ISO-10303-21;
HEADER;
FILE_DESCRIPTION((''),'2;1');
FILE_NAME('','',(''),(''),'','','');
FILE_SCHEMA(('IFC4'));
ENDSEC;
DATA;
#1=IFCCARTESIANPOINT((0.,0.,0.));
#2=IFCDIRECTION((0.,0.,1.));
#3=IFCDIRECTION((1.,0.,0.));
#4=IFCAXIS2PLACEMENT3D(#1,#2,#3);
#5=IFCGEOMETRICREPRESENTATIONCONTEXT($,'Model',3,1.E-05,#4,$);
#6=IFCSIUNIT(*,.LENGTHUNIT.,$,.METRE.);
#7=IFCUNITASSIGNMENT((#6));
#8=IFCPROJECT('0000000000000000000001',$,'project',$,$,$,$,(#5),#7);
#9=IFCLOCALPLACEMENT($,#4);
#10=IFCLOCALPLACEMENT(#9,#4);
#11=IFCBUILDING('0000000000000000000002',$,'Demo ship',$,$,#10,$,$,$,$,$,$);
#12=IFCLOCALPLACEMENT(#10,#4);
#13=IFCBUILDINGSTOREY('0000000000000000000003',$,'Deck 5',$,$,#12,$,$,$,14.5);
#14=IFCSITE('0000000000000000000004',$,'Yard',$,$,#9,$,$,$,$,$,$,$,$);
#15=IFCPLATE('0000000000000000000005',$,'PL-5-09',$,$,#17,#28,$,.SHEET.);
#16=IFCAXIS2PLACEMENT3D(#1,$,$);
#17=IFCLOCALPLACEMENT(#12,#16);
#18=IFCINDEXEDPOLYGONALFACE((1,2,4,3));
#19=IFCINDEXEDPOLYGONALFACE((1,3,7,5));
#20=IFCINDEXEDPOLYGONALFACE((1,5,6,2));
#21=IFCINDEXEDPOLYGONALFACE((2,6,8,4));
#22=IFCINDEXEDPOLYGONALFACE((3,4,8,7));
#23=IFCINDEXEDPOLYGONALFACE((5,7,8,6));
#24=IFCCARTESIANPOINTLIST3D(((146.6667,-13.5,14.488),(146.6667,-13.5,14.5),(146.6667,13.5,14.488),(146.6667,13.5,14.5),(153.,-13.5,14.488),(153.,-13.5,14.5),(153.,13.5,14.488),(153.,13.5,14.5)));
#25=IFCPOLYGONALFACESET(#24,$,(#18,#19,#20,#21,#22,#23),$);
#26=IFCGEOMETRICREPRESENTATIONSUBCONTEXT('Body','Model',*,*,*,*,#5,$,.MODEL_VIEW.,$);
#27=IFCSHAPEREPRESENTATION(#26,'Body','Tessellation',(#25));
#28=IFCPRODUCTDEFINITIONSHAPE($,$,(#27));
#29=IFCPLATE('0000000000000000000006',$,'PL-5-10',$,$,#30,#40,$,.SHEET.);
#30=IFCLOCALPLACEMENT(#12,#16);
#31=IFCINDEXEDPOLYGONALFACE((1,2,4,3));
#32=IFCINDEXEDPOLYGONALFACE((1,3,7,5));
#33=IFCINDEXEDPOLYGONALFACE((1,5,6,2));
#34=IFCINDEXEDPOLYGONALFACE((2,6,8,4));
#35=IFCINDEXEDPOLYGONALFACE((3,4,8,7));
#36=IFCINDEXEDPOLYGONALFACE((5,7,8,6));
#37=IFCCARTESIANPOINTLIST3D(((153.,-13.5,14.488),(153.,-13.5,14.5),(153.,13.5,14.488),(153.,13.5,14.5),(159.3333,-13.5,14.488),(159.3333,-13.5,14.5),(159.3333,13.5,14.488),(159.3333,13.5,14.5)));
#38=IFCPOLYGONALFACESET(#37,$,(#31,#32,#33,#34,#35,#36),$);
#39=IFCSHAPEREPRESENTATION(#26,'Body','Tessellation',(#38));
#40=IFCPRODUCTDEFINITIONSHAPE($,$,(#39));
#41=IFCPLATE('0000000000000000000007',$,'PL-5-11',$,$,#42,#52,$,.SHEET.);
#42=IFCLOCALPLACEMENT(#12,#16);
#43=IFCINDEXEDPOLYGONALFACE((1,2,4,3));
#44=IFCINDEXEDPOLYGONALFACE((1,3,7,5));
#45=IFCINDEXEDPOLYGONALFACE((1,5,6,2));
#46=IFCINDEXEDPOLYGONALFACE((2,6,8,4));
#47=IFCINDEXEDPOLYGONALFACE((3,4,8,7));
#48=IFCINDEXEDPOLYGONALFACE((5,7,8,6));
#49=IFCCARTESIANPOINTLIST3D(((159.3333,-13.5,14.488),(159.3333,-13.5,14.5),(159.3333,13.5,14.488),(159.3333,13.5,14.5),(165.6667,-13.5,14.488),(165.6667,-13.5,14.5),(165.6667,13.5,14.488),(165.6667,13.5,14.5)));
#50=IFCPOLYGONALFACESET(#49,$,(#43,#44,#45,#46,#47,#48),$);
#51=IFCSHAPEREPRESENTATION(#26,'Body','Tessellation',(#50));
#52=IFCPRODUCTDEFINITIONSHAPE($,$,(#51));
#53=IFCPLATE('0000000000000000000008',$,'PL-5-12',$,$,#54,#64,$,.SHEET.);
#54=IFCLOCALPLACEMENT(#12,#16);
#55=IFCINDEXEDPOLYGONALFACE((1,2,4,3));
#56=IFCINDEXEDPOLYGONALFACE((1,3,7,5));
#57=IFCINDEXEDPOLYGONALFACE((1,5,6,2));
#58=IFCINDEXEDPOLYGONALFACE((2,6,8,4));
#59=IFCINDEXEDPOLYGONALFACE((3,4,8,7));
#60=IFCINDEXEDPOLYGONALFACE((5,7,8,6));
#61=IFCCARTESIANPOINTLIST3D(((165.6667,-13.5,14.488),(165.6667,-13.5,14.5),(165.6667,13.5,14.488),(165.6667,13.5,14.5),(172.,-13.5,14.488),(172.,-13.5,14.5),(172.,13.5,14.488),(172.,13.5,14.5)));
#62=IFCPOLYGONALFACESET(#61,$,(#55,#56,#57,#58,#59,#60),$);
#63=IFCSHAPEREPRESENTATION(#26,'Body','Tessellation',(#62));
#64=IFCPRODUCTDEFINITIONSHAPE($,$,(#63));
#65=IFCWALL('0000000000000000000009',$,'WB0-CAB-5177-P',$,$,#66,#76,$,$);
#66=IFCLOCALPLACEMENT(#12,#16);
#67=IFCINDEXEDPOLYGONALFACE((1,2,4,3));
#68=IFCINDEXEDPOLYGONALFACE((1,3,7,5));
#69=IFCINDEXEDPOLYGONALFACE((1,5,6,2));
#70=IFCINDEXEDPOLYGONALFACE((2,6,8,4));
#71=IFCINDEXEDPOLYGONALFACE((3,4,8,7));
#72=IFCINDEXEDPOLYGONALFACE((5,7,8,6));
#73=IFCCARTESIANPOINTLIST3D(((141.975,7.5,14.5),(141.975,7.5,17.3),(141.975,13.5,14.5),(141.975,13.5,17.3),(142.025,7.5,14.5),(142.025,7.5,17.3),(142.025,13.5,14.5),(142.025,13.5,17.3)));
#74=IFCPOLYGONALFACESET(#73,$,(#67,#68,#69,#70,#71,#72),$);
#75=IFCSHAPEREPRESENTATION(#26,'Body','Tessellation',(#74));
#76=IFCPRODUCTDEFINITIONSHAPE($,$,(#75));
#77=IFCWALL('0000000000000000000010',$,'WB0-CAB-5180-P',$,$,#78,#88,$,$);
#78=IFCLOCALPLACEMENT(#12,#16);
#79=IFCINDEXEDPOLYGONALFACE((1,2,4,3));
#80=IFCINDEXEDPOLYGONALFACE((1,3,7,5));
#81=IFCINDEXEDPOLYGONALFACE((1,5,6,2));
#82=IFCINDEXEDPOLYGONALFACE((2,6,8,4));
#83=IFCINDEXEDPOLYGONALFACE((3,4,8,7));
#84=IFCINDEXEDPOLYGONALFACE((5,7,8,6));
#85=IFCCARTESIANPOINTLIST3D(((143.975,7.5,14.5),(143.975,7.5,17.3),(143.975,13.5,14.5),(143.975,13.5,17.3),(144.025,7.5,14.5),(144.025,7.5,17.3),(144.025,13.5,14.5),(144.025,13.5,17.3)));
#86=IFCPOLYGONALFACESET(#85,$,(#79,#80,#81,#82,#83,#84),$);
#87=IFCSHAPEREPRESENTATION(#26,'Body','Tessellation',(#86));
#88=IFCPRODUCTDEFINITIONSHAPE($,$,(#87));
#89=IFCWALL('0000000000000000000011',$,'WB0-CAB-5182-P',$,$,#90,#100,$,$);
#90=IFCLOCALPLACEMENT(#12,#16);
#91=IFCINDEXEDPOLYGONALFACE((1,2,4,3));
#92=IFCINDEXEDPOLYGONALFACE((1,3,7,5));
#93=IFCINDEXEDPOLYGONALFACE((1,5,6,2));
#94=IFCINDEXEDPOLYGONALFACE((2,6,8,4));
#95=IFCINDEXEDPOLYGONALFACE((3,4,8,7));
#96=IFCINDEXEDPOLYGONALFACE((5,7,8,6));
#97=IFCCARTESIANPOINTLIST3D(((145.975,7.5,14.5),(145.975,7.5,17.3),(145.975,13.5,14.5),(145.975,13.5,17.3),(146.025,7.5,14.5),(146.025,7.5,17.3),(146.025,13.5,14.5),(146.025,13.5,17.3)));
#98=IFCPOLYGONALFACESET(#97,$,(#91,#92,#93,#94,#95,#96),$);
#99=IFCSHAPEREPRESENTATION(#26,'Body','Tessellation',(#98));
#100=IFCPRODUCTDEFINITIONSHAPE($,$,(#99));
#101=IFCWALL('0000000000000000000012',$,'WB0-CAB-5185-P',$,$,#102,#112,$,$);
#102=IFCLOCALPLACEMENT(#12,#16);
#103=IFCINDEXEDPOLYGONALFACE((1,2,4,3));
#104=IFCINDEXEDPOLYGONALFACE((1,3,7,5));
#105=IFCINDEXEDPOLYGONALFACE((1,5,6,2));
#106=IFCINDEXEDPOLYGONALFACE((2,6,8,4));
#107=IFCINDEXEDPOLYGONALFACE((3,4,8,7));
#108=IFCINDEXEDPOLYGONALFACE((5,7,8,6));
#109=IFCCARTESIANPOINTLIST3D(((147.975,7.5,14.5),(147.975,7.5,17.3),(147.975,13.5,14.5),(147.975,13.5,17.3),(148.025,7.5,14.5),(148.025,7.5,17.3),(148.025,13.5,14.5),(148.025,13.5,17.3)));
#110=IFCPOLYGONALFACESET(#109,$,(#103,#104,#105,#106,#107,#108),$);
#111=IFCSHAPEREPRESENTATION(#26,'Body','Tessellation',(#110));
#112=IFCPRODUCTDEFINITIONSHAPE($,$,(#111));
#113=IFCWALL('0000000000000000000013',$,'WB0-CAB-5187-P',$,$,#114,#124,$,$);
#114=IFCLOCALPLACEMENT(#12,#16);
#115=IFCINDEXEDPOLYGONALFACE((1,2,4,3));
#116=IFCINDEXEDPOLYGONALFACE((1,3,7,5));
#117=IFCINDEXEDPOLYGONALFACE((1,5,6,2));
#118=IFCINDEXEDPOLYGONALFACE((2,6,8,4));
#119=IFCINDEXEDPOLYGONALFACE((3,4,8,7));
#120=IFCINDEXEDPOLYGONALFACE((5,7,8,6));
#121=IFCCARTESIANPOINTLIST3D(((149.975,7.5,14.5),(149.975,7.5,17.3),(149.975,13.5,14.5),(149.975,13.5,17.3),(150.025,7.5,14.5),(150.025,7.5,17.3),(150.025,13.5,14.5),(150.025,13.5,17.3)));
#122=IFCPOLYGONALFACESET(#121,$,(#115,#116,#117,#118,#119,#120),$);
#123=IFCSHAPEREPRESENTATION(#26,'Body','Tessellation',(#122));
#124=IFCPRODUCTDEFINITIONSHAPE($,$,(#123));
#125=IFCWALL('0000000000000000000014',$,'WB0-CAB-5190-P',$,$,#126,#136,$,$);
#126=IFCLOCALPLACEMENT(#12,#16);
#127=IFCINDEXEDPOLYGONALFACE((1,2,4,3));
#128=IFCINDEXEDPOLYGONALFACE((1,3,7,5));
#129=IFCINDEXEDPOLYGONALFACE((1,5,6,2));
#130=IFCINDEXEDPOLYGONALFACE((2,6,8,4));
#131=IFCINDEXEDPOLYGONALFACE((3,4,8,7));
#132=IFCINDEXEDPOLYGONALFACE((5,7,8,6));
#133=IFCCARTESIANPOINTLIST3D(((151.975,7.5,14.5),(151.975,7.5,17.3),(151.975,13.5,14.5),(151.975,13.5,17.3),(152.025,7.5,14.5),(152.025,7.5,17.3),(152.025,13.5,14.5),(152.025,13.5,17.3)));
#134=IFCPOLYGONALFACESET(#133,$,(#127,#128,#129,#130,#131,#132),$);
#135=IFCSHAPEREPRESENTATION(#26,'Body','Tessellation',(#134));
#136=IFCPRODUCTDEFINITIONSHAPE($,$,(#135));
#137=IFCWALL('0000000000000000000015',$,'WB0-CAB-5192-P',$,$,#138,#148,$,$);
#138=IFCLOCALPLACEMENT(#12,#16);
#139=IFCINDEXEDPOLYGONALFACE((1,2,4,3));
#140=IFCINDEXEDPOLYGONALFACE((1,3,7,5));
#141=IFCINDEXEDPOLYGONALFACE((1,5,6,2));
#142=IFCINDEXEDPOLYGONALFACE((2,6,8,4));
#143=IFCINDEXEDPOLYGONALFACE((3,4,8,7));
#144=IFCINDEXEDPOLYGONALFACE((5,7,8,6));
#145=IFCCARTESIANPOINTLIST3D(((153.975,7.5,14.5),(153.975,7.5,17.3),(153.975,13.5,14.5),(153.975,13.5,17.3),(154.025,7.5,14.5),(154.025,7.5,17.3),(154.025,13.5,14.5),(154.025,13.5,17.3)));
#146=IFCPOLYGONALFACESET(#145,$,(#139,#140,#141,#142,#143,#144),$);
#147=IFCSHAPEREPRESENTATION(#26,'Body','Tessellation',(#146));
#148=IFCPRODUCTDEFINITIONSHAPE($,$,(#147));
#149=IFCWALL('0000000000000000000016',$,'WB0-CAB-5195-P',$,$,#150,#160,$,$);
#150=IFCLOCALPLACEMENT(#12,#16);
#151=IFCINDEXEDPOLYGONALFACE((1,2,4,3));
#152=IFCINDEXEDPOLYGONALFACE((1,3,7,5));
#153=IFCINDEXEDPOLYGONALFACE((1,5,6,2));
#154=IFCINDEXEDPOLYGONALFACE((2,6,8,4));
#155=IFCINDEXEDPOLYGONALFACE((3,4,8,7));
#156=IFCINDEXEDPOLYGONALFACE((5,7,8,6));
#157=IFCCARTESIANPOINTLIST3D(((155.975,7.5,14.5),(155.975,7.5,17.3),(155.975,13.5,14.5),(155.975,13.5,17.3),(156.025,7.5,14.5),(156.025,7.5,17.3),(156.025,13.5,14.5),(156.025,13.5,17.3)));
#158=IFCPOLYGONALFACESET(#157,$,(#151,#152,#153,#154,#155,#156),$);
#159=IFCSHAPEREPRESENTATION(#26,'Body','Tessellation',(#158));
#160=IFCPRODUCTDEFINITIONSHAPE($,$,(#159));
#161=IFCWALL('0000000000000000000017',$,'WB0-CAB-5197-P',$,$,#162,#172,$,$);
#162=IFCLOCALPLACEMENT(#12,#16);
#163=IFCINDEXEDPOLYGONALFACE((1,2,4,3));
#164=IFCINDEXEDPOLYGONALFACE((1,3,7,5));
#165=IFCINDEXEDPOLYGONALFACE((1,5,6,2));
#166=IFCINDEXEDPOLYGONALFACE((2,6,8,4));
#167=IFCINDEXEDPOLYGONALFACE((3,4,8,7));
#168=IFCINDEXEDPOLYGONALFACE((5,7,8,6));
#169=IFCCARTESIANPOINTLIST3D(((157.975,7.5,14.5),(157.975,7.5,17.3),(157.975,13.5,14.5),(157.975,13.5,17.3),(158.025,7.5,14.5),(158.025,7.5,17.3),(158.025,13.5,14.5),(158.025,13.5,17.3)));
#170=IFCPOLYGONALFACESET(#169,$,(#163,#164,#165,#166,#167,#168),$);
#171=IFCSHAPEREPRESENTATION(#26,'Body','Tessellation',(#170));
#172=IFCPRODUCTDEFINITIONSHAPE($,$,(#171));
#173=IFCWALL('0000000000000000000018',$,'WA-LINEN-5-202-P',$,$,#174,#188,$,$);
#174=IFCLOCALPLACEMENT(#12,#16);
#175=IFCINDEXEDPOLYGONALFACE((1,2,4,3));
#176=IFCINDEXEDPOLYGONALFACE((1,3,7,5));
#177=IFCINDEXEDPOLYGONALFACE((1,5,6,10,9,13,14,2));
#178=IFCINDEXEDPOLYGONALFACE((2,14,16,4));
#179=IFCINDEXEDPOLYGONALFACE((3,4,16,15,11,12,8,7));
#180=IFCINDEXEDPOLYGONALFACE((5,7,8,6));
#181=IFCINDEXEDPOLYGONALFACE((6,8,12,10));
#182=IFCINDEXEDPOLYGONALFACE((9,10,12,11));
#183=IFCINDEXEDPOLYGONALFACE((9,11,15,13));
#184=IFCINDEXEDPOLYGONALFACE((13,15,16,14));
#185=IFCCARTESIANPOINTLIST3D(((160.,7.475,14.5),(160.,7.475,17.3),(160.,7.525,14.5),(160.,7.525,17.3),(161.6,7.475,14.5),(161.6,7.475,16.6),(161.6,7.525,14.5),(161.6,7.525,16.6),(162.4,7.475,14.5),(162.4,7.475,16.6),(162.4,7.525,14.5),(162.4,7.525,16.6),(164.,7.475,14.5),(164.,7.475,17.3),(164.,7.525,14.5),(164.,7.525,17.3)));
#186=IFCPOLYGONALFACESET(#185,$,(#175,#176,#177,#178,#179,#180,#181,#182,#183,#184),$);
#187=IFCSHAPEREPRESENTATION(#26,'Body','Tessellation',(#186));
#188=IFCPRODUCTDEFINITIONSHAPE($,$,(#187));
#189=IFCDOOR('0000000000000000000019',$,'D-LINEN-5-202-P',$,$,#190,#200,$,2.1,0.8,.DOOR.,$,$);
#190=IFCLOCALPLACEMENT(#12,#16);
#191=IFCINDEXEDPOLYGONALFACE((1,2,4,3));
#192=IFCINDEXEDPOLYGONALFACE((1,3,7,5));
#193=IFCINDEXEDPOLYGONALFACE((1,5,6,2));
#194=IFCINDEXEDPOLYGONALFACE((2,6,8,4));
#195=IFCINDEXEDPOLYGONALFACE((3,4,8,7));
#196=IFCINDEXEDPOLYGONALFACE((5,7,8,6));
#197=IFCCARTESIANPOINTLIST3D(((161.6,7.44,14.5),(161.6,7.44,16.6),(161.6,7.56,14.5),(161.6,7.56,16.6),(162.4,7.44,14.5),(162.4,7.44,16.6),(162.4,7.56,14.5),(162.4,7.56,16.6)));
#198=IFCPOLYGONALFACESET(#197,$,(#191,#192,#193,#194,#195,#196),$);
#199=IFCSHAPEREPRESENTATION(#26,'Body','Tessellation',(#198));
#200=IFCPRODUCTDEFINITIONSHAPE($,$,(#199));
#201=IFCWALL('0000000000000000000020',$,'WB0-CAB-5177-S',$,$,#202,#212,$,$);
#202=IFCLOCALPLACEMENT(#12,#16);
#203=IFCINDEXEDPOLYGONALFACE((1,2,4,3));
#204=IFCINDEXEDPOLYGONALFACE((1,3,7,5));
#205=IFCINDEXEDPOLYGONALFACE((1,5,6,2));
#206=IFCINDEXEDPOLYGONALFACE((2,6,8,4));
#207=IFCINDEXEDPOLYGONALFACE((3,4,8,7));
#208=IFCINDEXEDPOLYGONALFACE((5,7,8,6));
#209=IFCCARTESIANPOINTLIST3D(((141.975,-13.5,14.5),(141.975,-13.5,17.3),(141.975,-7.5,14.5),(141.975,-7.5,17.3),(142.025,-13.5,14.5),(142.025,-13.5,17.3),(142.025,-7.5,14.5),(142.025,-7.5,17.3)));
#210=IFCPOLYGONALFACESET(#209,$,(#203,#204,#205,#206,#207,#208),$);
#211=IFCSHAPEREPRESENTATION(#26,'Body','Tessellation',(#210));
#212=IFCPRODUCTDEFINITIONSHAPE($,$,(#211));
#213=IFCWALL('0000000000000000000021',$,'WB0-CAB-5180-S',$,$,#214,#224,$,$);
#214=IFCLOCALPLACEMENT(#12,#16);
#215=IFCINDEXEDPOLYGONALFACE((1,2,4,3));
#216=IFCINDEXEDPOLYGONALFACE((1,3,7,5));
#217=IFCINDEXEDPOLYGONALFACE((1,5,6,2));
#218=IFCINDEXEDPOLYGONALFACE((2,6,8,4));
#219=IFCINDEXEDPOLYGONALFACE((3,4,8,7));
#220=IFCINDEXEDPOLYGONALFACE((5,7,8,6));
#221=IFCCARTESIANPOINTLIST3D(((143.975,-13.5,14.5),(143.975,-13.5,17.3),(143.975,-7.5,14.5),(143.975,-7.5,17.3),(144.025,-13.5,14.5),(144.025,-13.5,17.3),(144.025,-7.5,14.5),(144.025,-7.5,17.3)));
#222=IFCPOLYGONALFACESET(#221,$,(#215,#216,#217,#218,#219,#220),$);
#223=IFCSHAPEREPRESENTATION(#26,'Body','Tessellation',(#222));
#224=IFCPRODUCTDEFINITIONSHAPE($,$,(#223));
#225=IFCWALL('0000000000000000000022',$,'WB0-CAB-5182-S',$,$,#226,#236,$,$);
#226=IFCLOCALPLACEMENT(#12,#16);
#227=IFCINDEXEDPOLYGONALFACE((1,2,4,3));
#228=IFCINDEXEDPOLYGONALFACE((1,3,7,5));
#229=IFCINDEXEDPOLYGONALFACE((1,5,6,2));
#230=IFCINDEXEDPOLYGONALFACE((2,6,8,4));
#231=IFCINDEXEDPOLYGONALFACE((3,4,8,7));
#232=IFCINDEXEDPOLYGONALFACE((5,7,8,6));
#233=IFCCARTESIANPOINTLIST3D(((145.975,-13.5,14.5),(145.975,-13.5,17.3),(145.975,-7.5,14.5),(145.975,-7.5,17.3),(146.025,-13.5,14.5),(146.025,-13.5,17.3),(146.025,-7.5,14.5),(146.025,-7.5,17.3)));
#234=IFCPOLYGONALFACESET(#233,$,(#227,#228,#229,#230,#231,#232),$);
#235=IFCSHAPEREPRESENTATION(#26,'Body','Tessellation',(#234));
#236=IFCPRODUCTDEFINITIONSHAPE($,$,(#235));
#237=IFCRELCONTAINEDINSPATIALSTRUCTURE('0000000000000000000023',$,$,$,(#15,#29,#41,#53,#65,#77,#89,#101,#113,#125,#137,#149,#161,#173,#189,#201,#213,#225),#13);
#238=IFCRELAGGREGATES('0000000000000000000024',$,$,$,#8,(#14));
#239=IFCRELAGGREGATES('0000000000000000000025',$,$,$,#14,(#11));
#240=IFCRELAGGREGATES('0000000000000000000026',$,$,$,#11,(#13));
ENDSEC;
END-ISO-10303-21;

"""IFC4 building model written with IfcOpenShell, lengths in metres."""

from ifc_helpers import new_model, si_unit, frame, frame_2d, origin, origin_with_axes, place, context, subcontext, project, spatial, rectangle, extrude, element, fill, save


model = new_model("IFC4")

# Units and contexts
model_context = context("Model", 3, precision=1e-05, world=origin_with_axes())
body_context = subcontext(model_context, "Body", "Model", "MODEL_VIEW")
ifc_project = project(units=[si_unit("LENGTHUNIT", "METRE")], contexts=[model_context])

# Site, building, storey
site_placement = place(None, origin_with_axes())
site = spatial("IfcSite", under=ifc_project, at=site_placement, Name="Yard")
building_placement = place(site_placement, origin_with_axes())
building = spatial("IfcBuilding", under=site, at=building_placement, Name="Demo ship")
storey_placement = place(building_placement, origin_with_axes())
storey = spatial("IfcBuildingStorey", under=building, at=storey_placement, Name="Deck 5", Elevation=14.5)

# Plates
for number, where, z_axis, x_axis, name in (
    (1, (146.6667, -13.5, 14.488), (0.0, 0.0, 1.0), (1.0, 0.0, 0.0), "PL-5-09"),
    (2, (153.0, -13.5, 14.488), (0.0, 0.0, 1.0), (1.0, 0.0, 0.0), "PL-5-10"),
):
    element("IfcPlate", number, at=place(storey_placement, frame(where, z_axis=z_axis, x_axis=x_axis)), inside=storey, Name=name, PredefinedType="SHEET", context=body_context, shape_type="SweptSolid", body=[
        extrude(rectangle(XDim=6.3333, YDim=27.0, at=frame_2d((3.1667, 13.5))), origin(), (0.0, 0.0, 1.0), 0.012),
    ])
plate_1_placement = place(storey_placement, frame((159.3333, -13.5, 14.488), z_axis=(0.0, 0.0, 1.0), x_axis=(1.0, 0.0, 0.0)))
element("IfcPlate", 3, at=plate_1_placement, inside=storey, Name="PL-5-11", PredefinedType="SHEET", context=body_context, shape_type="SweptSolid", body=[
    extrude(rectangle(XDim=6.3334, YDim=27.0, at=frame_2d((3.1667, 13.5))), origin(), (0.0, 0.0, 1.0), 0.012),
])
plate_2_placement = place(storey_placement, frame((165.6667, -13.5, 14.488), z_axis=(0.0, 0.0, 1.0), x_axis=(1.0, 0.0, 0.0)))
element("IfcPlate", 4, at=plate_2_placement, inside=storey, Name="PL-5-12", PredefinedType="SHEET", context=body_context, shape_type="SweptSolid", body=[
    extrude(rectangle(XDim=6.3333, YDim=27.0, at=frame_2d((3.1667, 13.5))), origin(), (0.0, 0.0, 1.0), 0.012),
])

# Walls
for number, where, z_axis, x_axis, name in (
    (5, (141.975, 7.5, 14.5), (0.0, 0.0, 1.0), (1.0, 0.0, 0.0), "WB0-CAB-5177-P"),
    (6, (143.975, 7.5, 14.5), (0.0, 0.0, 1.0), (1.0, 0.0, 0.0), "WB0-CAB-5180-P"),
    (7, (145.975, 7.5, 14.5), (0.0, 0.0, 1.0), (1.0, 0.0, 0.0), "WB0-CAB-5182-P"),
    (8, (147.975, 7.5, 14.5), (0.0, 0.0, 1.0), (1.0, 0.0, 0.0), "WB0-CAB-5185-P"),
    (9, (149.975, 7.5, 14.5), (0.0, 0.0, 1.0), (1.0, 0.0, 0.0), "WB0-CAB-5187-P"),
    (10, (151.975, 7.5, 14.5), (0.0, 0.0, 1.0), (1.0, 0.0, 0.0), "WB0-CAB-5190-P"),
    (11, (153.975, 7.5, 14.5), (0.0, 0.0, 1.0), (1.0, 0.0, 0.0), "WB0-CAB-5192-P"),
    (12, (155.975, 7.5, 14.5), (0.0, 0.0, 1.0), (1.0, 0.0, 0.0), "WB0-CAB-5195-P"),
    (13, (157.975, 7.5, 14.5), (0.0, 0.0, 1.0), (1.0, 0.0, 0.0), "WB0-CAB-5197-P"),
):
    element("IfcWall", number, at=place(storey_placement, frame(where, z_axis=z_axis, x_axis=x_axis)), inside=storey, Name=name, context=body_context, shape_type="SweptSolid", body=[
        extrude(rectangle(XDim=0.05, YDim=6.0, at=frame_2d((0.025, 3.0))), origin(), (0.0, 0.0, 1.0), 2.8),
    ])

# Wall, opening, door
wall_1_placement = place(storey_placement, frame((160.0, 7.475, 14.5), z_axis=(0.0, 0.0, 1.0), x_axis=(1.0, 0.0, 0.0)))
wall_1 = element("IfcWall", 14, at=wall_1_placement, inside=storey, Name="WA-LINEN-5-202-P", context=body_context, shape_type="SweptSolid", body=[
    extrude(rectangle(XDim=4.0, YDim=0.05, at=frame_2d((2.0, 0.025))), origin(), (0.0, 0.0, 1.0), 2.8),
])
opening_1_placement = place(None, frame((161.6, 7.44, 14.5), z_axis=(0.0, 0.0, 1.0), x_axis=(1.0, 0.0, 0.0)))
opening_1 = element("IfcOpeningElement", 15, at=opening_1_placement, cuts=wall_1, context=body_context, shape_type="SweptSolid", body=[
    extrude(rectangle(XDim=0.8, YDim=0.12, at=frame_2d((0.4, 0.06))), origin(), (0.0, 0.0, 1.0), 2.1),
])
door_1_placement = place(storey_placement, frame((161.6, 7.44, 14.5), z_axis=(0.0, 0.0, 1.0), x_axis=(1.0, 0.0, 0.0)))
door_1 = element("IfcDoor", 16, at=door_1_placement, inside=storey, Name="D-LINEN-5-202-P", OverallHeight=2.1, OverallWidth=0.8, PredefinedType="DOOR", context=body_context, shape_type="SweptSolid", body=[
    extrude(rectangle(XDim=0.8, YDim=0.12, at=frame_2d((0.4, 0.06))), origin(), (0.0, 0.0, 1.0), 2.1),
])
fill(opening_1, door_1)

# Walls
for number, where, z_axis, x_axis, name in (
    (17, (141.975, -13.5, 14.5), (0.0, 0.0, 1.0), (1.0, 0.0, 0.0), "WB0-CAB-5177-S"),
    (18, (143.975, -13.5, 14.5), (0.0, 0.0, 1.0), (1.0, 0.0, 0.0), "WB0-CAB-5180-S"),
    (19, (145.975, -13.5, 14.5), (0.0, 0.0, 1.0), (1.0, 0.0, 0.0), "WB0-CAB-5182-S"),
):
    element("IfcWall", number, at=place(storey_placement, frame(where, z_axis=z_axis, x_axis=x_axis)), inside=storey, Name=name, context=body_context, shape_type="SweptSolid", body=[
        extrude(rectangle(XDim=0.05, YDim=6.0, at=frame_2d((0.025, 3.0))), origin(), (0.0, 0.0, 1.0), 2.8),
    ])

save(model, "model.ifc")
